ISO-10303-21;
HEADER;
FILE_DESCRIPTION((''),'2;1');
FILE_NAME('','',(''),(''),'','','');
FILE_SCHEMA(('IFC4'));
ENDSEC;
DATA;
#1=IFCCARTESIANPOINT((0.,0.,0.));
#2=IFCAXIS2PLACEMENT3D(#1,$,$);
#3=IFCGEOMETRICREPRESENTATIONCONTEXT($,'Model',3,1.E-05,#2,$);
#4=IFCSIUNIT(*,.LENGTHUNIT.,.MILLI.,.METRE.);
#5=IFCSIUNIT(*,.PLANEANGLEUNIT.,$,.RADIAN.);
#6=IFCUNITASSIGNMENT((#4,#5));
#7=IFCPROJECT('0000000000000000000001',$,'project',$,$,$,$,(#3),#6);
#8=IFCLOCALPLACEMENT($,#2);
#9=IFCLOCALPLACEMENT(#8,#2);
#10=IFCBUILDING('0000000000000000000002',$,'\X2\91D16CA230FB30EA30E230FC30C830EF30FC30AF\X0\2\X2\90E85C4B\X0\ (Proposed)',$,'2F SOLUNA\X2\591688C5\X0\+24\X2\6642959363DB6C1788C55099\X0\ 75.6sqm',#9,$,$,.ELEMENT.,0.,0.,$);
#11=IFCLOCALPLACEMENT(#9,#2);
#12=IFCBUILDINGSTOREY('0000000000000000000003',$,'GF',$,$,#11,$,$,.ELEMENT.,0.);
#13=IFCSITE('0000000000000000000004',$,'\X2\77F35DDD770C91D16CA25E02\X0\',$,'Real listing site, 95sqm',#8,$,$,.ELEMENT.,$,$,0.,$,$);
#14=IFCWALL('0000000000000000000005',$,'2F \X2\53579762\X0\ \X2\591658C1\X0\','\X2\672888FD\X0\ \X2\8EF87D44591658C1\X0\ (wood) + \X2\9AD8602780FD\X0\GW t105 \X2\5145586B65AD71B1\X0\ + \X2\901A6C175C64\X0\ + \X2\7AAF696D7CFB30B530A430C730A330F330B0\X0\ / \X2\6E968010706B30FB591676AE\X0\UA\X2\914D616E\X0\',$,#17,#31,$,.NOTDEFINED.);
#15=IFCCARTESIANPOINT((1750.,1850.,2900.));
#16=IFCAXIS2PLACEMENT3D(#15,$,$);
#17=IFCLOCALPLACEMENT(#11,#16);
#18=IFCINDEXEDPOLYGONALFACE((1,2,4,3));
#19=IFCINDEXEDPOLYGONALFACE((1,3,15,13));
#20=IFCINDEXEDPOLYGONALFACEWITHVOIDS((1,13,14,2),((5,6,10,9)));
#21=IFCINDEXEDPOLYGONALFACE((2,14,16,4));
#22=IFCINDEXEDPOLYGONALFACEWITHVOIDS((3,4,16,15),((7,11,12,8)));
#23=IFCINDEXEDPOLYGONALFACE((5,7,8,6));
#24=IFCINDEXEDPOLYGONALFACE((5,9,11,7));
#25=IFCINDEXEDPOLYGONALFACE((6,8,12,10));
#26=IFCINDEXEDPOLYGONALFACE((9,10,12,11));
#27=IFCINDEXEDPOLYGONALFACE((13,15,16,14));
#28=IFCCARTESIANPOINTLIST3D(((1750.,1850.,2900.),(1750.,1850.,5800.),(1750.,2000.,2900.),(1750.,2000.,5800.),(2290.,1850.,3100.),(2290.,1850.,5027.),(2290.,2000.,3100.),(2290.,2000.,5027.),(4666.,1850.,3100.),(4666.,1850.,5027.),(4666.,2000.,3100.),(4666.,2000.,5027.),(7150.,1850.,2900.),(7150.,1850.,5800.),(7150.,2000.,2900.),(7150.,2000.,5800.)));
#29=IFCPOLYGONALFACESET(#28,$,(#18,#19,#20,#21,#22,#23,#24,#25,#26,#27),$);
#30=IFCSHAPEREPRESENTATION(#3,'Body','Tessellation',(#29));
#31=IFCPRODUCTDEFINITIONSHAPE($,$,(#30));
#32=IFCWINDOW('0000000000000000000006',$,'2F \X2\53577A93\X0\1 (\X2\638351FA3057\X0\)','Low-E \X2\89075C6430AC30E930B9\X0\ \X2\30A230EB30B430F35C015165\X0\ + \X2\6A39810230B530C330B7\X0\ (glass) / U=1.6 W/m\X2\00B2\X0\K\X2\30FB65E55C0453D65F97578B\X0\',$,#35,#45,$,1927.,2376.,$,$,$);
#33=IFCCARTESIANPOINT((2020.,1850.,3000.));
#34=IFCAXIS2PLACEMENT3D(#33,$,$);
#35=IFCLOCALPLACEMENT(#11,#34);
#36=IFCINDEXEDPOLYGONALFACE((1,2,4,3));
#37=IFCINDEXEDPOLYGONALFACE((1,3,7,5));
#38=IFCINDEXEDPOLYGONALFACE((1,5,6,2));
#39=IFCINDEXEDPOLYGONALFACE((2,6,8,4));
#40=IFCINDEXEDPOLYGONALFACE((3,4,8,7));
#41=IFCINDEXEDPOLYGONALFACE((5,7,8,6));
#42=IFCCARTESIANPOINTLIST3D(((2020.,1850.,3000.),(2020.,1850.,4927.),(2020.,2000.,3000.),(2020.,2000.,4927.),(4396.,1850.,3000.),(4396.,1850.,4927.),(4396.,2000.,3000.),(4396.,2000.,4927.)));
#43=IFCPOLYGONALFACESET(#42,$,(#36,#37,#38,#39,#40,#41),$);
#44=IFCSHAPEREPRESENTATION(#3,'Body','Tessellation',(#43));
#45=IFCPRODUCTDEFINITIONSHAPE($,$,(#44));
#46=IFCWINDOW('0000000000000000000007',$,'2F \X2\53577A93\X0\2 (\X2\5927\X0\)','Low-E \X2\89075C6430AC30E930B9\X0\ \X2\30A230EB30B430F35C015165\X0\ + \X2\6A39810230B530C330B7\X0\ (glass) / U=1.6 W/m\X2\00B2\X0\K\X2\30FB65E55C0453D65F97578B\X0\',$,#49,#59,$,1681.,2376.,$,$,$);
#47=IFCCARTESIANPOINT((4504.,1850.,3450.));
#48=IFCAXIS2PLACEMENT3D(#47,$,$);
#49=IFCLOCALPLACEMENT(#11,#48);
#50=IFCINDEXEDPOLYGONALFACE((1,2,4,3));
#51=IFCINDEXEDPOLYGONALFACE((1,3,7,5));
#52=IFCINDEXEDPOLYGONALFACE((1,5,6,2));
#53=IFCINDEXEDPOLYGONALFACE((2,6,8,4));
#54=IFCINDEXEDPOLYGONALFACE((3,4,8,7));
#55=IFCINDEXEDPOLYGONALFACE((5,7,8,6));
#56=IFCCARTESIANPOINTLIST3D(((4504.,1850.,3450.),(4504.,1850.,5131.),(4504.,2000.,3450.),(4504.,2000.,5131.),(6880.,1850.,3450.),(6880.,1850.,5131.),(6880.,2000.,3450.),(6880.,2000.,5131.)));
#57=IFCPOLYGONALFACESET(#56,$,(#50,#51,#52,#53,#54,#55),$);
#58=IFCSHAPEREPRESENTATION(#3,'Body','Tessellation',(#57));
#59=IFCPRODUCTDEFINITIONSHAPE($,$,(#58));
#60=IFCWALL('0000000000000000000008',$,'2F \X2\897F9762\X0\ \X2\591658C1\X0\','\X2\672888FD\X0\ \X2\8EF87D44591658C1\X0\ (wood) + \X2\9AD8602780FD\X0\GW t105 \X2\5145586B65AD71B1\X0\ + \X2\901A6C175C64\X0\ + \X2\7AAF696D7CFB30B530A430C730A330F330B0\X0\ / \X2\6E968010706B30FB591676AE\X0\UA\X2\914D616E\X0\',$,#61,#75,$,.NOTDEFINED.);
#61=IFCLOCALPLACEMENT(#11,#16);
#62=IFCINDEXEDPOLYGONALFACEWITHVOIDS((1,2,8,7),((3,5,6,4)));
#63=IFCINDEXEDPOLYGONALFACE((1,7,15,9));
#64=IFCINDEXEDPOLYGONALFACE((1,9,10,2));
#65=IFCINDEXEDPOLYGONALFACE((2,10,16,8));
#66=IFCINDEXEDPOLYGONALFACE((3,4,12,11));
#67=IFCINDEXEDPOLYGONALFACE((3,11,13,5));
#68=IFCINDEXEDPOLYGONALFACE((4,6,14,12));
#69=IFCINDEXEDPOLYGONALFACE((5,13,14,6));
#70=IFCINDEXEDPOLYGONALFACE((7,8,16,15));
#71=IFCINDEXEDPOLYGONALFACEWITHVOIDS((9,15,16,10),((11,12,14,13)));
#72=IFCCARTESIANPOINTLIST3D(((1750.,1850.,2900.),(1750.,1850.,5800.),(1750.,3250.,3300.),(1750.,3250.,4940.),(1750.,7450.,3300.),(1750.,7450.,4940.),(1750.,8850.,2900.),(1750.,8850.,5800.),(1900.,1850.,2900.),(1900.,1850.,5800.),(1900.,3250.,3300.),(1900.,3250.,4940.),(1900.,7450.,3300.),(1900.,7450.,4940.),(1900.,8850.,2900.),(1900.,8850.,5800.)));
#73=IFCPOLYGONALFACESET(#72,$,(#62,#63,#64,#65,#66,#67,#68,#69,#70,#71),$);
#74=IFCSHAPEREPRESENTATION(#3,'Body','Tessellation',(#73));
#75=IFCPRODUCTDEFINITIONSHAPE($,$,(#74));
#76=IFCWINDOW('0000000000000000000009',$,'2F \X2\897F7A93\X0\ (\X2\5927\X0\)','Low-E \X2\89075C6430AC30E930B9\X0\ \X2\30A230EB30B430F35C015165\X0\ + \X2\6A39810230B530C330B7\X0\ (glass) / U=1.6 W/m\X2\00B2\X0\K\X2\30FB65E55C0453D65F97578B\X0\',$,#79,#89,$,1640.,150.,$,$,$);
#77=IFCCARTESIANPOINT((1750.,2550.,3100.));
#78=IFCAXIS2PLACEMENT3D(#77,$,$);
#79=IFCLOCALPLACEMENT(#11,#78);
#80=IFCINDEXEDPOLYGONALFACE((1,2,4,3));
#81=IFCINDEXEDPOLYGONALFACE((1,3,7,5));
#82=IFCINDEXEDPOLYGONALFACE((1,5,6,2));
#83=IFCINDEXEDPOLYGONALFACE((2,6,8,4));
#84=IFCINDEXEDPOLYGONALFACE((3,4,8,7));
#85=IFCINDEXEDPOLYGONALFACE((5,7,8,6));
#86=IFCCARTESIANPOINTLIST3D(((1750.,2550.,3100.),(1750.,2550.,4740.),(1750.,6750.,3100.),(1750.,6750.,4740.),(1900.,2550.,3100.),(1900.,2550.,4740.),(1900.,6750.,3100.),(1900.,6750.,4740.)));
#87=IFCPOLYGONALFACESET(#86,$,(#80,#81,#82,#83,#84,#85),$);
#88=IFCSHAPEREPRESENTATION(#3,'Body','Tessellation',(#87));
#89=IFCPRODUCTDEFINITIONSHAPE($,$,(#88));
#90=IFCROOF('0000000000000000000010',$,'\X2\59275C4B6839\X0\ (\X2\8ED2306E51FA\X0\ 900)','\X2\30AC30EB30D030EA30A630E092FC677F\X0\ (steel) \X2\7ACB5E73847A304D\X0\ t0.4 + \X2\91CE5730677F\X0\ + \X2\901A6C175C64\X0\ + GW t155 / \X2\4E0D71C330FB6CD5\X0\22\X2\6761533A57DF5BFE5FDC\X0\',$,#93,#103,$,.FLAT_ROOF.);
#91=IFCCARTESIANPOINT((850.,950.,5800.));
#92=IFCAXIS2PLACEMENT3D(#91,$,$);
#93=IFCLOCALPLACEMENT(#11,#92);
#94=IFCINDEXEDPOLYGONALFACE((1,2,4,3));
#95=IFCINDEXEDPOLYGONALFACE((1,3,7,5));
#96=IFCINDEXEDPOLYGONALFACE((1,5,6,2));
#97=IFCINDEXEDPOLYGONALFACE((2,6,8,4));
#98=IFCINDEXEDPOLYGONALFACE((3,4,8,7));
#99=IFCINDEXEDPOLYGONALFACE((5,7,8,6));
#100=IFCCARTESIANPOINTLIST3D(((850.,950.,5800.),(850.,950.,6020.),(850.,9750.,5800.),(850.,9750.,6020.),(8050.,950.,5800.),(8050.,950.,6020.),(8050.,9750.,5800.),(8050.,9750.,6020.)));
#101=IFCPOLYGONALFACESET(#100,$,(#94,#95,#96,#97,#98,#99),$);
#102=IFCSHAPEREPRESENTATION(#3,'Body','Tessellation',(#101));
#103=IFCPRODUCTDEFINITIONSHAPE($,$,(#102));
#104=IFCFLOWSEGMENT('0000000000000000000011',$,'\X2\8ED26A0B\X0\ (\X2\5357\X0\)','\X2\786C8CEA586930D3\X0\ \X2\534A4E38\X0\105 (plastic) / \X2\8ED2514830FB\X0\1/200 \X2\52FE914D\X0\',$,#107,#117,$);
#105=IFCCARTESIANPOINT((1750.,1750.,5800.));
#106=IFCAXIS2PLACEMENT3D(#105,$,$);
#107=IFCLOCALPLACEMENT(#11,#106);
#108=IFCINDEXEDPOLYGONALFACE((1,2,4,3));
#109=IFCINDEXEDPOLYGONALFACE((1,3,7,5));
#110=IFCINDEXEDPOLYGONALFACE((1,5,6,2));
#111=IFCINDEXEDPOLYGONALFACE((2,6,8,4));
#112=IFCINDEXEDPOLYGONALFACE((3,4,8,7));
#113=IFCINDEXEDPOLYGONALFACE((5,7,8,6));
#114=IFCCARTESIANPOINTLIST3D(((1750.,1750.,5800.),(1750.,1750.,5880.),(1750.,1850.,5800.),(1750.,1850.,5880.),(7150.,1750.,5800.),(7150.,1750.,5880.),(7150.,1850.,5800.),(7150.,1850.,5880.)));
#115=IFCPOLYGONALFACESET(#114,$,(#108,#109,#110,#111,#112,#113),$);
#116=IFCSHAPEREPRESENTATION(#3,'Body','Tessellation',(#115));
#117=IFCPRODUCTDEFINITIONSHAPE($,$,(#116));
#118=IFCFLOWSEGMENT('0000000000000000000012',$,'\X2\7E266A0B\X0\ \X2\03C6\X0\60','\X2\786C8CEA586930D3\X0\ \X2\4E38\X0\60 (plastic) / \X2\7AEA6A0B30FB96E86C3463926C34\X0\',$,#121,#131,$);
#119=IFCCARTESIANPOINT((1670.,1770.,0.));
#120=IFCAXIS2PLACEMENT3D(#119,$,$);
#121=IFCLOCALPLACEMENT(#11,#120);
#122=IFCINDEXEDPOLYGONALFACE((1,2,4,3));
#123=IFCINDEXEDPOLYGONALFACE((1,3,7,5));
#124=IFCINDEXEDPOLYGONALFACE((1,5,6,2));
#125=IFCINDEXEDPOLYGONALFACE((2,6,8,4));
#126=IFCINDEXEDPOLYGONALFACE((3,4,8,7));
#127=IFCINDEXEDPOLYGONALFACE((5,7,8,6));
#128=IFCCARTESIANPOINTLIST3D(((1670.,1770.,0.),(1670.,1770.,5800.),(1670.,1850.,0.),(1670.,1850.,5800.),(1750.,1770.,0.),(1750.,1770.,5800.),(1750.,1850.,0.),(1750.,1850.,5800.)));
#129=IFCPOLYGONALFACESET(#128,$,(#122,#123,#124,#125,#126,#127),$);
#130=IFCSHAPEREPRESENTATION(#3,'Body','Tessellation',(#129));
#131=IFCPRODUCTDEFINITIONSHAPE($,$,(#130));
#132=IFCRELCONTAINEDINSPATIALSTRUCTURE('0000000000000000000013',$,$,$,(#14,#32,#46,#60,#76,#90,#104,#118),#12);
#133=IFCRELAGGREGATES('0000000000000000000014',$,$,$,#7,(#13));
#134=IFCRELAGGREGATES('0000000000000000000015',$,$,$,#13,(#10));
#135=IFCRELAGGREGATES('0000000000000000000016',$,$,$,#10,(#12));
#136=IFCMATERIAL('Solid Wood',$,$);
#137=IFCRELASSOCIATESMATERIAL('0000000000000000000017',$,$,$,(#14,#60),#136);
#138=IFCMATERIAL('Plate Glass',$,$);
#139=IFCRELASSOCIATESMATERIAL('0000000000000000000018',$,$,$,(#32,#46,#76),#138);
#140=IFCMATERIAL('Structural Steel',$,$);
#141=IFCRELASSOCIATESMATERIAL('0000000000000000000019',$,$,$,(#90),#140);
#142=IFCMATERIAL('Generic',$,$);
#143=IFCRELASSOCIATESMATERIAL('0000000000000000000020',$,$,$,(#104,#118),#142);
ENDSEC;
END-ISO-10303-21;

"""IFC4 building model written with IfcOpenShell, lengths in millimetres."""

from ifc_helpers import new_model, si_unit, frame, frame_2d, origin, place, context, project, spatial, rectangle, extrude, material, element, fill, save


model = new_model("IFC4")

# Units and contexts
model_context = context("Model", 3, precision=1e-05, world=origin())
ifc_project = project(units=[si_unit("LENGTHUNIT", "METRE", prefix="MILLI"), si_unit("PLANEANGLEUNIT", "RADIAN")], contexts=[model_context])

# Site, building, storey
site_placement = place(None, origin())
site = spatial("IfcSite", under=ifc_project, at=site_placement, Name="石川県金沢市", ObjectType="Real listing site, 95sqm", CompositionType="ELEMENT", RefElevation=0.0)
building_placement = place(site_placement, origin())
building = spatial("IfcBuilding", under=site, at=building_placement, Name="金沢・リモートワーク2部屋 (Proposed)", ObjectType="2F SOLUNA外装+24時間換気装備 75.6sqm", CompositionType="ELEMENT", ElevationOfRefHeight=0.0, ElevationOfTerrain=0.0)
storey_placement = place(building_placement, origin())
storey = spatial("IfcBuildingStorey", under=building, at=storey_placement, Name="GF", CompositionType="ELEMENT", Elevation=0.0)

# Shared definitions
ifc_material_1 = material(Name="Solid Wood")

# Shared definitions
ifc_material_2 = material(Name="Plate Glass")

# Wall, openings, windows
wall_1_placement = place(storey_placement, frame((1750.0, 1850.0, 2900.0)))
wall_1 = element("IfcWall", 1, at=wall_1_placement, inside=storey, material=ifc_material_1, Name="2F 南面 外壁", Description="木製 軸組外壁 (wood) + 高性能GW t105 充填断熱 + 通気層 + 窯業系サイディング / 準耐火・外皮UA配慮", PredefinedType="NOTDEFINED", context=model_context, shape_type="SweptSolid", body=[
    extrude(rectangle(XDim=5400.0, YDim=150.0, at=frame_2d((2700.0, 75.0))), frame((1750.0, 1850.0, 2900.0)), (0.0, 0.0, 1.0), 2900.0),
])
opening_1_placement = place(storey_placement, frame((2020.0, 1850.0, 3000.0)))
opening_1 = element("IfcOpeningElement", 2, at=opening_1_placement, cuts=wall_1, PredefinedType="NOTDEFINED", context=model_context, shape_type="SweptSolid", body=[
    extrude(rectangle(XDim=2376.0, YDim=150.0, at=frame_2d((1188.0, 75.0))), frame((2020.0, 1850.0, 3000.0)), (0.0, 0.0, 1.0), 1927.0),
])
opening_2_placement = place(storey_placement, frame((4504.0, 1850.0, 3450.0)))
opening_2 = element("IfcOpeningElement", 3, at=opening_2_placement, cuts=wall_1, PredefinedType="NOTDEFINED", context=model_context, shape_type="SweptSolid", body=[
    extrude(rectangle(XDim=2376.0, YDim=150.0, at=frame_2d((1188.0, 75.0))), frame((4504.0, 1850.0, 3450.0)), (0.0, 0.0, 1.0), 1681.0),
])
window_1_placement = place(storey_placement, frame((2020.0, 1850.0, 3000.0)))
window_1 = element("IfcWindow", 4, at=window_1_placement, inside=storey, material=ifc_material_2, Name="2F 南窓1 (掃出し)", Description="Low-E 複層ガラス アルゴン封入 + 樹脂サッシ (glass) / U=1.6 W/m²K・日射取得型", OverallHeight=1927.0, OverallWidth=2376.0, context=model_context, shape_type="SweptSolid", body=[
    extrude(rectangle(XDim=2376.0, YDim=150.0, at=frame_2d((1188.0, 75.0))), frame((2020.0, 1850.0, 3000.0)), (0.0, 0.0, 1.0), 1927.0),
])
fill(opening_1, window_1)
window_2_placement = place(storey_placement, frame((4504.0, 1850.0, 3450.0)))
window_2 = element("IfcWindow", 5, at=window_2_placement, inside=storey, material=ifc_material_2, Name="2F 南窓2 (大)", Description="Low-E 複層ガラス アルゴン封入 + 樹脂サッシ (glass) / U=1.6 W/m²K・日射取得型", OverallHeight=1681.0, OverallWidth=2376.0, context=model_context, shape_type="SweptSolid", body=[
    extrude(rectangle(XDim=2376.0, YDim=150.0, at=frame_2d((1188.0, 75.0))), frame((4504.0, 1850.0, 3450.0)), (0.0, 0.0, 1.0), 1681.0),
])
fill(opening_2, window_2)

# Wall, opening, window
wall_2_placement = place(storey_placement, frame((1750.0, 1850.0, 2900.0)))
wall_2 = element("IfcWall", 6, at=wall_2_placement, inside=storey, material=ifc_material_1, Name="2F 西面 外壁", Description="木製 軸組外壁 (wood) + 高性能GW t105 充填断熱 + 通気層 + 窯業系サイディング / 準耐火・外皮UA配慮", PredefinedType="NOTDEFINED", context=model_context, shape_type="SweptSolid", body=[
    extrude(rectangle(XDim=150.0, YDim=7000.0, at=frame_2d((75.0, 3500.0))), frame((1750.0, 1850.0, 2900.0)), (0.0, 0.0, 1.0), 2900.0),
])
opening_3_placement = place(storey_placement, frame((1750.0, 2550.0, 3100.0)))
opening_3 = element("IfcOpeningElement", 7, at=opening_3_placement, cuts=wall_2, PredefinedType="NOTDEFINED", context=model_context, shape_type="SweptSolid", body=[
    extrude(rectangle(XDim=150.0, YDim=4200.0, at=frame_2d((75.0, 2100.0))), frame((1750.0, 2550.0, 3100.0)), (0.0, 0.0, 1.0), 1640.0),
])
window_3_placement = place(storey_placement, frame((1750.0, 2550.0, 3100.0)))
window_3 = element("IfcWindow", 8, at=window_3_placement, inside=storey, material=ifc_material_2, Name="2F 西窓 (大)", Description="Low-E 複層ガラス アルゴン封入 + 樹脂サッシ (glass) / U=1.6 W/m²K・日射取得型", OverallHeight=1640.0, OverallWidth=150.0, context=model_context, shape_type="SweptSolid", body=[
    extrude(rectangle(XDim=150.0, YDim=4200.0, at=frame_2d((75.0, 2100.0))), frame((1750.0, 2550.0, 3100.0)), (0.0, 0.0, 1.0), 1640.0),
])
fill(opening_3, window_3)

# Roof
ifc_material_3 = material(Name="Structural Steel")
roof_placement = place(storey_placement, frame((850.0, 950.0, 5800.0)))
element("IfcRoof", 9, at=roof_placement, inside=storey, material=ifc_material_3, Name="大屋根 (軒の出 900)", Description="ガルバリウム鋼板 (steel) 立平葺き t0.4 + 野地板 + 通気層 + GW t155 / 不燃・法22条区域対応", PredefinedType="FLAT_ROOF", context=model_context, shape_type="SweptSolid", body=[
    extrude(rectangle(XDim=7200.0, YDim=8800.0, at=frame_2d((3600.0, 4400.0))), frame((850.0, 950.0, 5800.0)), (0.0, 0.0, 1.0), 220.0),
])

# Flow segments
ifc_material_4 = material(Name="Generic")
flow_segment_1_placement = place(storey_placement, frame((1750.0, 1750.0, 5800.0)))
element("IfcFlowSegment", 10, at=flow_segment_1_placement, inside=storey, material=ifc_material_4, Name="軒樋 (南)", Description="硬質塩ビ 半丸105 (plastic) / 軒先・1/200 勾配", context=model_context, shape_type="SweptSolid", body=[
    extrude(rectangle(XDim=5400.0, YDim=100.0, at=frame_2d((2700.0, 50.0))), frame((1750.0, 1750.0, 5800.0)), (0.0, 0.0, 1.0), 80.0),
])
flow_segment_2_placement = place(storey_placement, frame((1670.0, 1770.0, 0.0)))
element("IfcFlowSegment", 11, at=flow_segment_2_placement, inside=storey, material=ifc_material_4, Name="縦樋 φ60", Description="硬質塩ビ 丸60 (plastic) / 竪樋・雨水排水", context=model_context, shape_type="SweptSolid", body=[
    extrude(rectangle(XDim=80.0, YDim=80.0, at=frame_2d((40.0, 40.0))), frame((1670.0, 1770.0, 0.0)), (0.0, 0.0, 1.0), 5800.0),
])

save(model, "model.ifc")
